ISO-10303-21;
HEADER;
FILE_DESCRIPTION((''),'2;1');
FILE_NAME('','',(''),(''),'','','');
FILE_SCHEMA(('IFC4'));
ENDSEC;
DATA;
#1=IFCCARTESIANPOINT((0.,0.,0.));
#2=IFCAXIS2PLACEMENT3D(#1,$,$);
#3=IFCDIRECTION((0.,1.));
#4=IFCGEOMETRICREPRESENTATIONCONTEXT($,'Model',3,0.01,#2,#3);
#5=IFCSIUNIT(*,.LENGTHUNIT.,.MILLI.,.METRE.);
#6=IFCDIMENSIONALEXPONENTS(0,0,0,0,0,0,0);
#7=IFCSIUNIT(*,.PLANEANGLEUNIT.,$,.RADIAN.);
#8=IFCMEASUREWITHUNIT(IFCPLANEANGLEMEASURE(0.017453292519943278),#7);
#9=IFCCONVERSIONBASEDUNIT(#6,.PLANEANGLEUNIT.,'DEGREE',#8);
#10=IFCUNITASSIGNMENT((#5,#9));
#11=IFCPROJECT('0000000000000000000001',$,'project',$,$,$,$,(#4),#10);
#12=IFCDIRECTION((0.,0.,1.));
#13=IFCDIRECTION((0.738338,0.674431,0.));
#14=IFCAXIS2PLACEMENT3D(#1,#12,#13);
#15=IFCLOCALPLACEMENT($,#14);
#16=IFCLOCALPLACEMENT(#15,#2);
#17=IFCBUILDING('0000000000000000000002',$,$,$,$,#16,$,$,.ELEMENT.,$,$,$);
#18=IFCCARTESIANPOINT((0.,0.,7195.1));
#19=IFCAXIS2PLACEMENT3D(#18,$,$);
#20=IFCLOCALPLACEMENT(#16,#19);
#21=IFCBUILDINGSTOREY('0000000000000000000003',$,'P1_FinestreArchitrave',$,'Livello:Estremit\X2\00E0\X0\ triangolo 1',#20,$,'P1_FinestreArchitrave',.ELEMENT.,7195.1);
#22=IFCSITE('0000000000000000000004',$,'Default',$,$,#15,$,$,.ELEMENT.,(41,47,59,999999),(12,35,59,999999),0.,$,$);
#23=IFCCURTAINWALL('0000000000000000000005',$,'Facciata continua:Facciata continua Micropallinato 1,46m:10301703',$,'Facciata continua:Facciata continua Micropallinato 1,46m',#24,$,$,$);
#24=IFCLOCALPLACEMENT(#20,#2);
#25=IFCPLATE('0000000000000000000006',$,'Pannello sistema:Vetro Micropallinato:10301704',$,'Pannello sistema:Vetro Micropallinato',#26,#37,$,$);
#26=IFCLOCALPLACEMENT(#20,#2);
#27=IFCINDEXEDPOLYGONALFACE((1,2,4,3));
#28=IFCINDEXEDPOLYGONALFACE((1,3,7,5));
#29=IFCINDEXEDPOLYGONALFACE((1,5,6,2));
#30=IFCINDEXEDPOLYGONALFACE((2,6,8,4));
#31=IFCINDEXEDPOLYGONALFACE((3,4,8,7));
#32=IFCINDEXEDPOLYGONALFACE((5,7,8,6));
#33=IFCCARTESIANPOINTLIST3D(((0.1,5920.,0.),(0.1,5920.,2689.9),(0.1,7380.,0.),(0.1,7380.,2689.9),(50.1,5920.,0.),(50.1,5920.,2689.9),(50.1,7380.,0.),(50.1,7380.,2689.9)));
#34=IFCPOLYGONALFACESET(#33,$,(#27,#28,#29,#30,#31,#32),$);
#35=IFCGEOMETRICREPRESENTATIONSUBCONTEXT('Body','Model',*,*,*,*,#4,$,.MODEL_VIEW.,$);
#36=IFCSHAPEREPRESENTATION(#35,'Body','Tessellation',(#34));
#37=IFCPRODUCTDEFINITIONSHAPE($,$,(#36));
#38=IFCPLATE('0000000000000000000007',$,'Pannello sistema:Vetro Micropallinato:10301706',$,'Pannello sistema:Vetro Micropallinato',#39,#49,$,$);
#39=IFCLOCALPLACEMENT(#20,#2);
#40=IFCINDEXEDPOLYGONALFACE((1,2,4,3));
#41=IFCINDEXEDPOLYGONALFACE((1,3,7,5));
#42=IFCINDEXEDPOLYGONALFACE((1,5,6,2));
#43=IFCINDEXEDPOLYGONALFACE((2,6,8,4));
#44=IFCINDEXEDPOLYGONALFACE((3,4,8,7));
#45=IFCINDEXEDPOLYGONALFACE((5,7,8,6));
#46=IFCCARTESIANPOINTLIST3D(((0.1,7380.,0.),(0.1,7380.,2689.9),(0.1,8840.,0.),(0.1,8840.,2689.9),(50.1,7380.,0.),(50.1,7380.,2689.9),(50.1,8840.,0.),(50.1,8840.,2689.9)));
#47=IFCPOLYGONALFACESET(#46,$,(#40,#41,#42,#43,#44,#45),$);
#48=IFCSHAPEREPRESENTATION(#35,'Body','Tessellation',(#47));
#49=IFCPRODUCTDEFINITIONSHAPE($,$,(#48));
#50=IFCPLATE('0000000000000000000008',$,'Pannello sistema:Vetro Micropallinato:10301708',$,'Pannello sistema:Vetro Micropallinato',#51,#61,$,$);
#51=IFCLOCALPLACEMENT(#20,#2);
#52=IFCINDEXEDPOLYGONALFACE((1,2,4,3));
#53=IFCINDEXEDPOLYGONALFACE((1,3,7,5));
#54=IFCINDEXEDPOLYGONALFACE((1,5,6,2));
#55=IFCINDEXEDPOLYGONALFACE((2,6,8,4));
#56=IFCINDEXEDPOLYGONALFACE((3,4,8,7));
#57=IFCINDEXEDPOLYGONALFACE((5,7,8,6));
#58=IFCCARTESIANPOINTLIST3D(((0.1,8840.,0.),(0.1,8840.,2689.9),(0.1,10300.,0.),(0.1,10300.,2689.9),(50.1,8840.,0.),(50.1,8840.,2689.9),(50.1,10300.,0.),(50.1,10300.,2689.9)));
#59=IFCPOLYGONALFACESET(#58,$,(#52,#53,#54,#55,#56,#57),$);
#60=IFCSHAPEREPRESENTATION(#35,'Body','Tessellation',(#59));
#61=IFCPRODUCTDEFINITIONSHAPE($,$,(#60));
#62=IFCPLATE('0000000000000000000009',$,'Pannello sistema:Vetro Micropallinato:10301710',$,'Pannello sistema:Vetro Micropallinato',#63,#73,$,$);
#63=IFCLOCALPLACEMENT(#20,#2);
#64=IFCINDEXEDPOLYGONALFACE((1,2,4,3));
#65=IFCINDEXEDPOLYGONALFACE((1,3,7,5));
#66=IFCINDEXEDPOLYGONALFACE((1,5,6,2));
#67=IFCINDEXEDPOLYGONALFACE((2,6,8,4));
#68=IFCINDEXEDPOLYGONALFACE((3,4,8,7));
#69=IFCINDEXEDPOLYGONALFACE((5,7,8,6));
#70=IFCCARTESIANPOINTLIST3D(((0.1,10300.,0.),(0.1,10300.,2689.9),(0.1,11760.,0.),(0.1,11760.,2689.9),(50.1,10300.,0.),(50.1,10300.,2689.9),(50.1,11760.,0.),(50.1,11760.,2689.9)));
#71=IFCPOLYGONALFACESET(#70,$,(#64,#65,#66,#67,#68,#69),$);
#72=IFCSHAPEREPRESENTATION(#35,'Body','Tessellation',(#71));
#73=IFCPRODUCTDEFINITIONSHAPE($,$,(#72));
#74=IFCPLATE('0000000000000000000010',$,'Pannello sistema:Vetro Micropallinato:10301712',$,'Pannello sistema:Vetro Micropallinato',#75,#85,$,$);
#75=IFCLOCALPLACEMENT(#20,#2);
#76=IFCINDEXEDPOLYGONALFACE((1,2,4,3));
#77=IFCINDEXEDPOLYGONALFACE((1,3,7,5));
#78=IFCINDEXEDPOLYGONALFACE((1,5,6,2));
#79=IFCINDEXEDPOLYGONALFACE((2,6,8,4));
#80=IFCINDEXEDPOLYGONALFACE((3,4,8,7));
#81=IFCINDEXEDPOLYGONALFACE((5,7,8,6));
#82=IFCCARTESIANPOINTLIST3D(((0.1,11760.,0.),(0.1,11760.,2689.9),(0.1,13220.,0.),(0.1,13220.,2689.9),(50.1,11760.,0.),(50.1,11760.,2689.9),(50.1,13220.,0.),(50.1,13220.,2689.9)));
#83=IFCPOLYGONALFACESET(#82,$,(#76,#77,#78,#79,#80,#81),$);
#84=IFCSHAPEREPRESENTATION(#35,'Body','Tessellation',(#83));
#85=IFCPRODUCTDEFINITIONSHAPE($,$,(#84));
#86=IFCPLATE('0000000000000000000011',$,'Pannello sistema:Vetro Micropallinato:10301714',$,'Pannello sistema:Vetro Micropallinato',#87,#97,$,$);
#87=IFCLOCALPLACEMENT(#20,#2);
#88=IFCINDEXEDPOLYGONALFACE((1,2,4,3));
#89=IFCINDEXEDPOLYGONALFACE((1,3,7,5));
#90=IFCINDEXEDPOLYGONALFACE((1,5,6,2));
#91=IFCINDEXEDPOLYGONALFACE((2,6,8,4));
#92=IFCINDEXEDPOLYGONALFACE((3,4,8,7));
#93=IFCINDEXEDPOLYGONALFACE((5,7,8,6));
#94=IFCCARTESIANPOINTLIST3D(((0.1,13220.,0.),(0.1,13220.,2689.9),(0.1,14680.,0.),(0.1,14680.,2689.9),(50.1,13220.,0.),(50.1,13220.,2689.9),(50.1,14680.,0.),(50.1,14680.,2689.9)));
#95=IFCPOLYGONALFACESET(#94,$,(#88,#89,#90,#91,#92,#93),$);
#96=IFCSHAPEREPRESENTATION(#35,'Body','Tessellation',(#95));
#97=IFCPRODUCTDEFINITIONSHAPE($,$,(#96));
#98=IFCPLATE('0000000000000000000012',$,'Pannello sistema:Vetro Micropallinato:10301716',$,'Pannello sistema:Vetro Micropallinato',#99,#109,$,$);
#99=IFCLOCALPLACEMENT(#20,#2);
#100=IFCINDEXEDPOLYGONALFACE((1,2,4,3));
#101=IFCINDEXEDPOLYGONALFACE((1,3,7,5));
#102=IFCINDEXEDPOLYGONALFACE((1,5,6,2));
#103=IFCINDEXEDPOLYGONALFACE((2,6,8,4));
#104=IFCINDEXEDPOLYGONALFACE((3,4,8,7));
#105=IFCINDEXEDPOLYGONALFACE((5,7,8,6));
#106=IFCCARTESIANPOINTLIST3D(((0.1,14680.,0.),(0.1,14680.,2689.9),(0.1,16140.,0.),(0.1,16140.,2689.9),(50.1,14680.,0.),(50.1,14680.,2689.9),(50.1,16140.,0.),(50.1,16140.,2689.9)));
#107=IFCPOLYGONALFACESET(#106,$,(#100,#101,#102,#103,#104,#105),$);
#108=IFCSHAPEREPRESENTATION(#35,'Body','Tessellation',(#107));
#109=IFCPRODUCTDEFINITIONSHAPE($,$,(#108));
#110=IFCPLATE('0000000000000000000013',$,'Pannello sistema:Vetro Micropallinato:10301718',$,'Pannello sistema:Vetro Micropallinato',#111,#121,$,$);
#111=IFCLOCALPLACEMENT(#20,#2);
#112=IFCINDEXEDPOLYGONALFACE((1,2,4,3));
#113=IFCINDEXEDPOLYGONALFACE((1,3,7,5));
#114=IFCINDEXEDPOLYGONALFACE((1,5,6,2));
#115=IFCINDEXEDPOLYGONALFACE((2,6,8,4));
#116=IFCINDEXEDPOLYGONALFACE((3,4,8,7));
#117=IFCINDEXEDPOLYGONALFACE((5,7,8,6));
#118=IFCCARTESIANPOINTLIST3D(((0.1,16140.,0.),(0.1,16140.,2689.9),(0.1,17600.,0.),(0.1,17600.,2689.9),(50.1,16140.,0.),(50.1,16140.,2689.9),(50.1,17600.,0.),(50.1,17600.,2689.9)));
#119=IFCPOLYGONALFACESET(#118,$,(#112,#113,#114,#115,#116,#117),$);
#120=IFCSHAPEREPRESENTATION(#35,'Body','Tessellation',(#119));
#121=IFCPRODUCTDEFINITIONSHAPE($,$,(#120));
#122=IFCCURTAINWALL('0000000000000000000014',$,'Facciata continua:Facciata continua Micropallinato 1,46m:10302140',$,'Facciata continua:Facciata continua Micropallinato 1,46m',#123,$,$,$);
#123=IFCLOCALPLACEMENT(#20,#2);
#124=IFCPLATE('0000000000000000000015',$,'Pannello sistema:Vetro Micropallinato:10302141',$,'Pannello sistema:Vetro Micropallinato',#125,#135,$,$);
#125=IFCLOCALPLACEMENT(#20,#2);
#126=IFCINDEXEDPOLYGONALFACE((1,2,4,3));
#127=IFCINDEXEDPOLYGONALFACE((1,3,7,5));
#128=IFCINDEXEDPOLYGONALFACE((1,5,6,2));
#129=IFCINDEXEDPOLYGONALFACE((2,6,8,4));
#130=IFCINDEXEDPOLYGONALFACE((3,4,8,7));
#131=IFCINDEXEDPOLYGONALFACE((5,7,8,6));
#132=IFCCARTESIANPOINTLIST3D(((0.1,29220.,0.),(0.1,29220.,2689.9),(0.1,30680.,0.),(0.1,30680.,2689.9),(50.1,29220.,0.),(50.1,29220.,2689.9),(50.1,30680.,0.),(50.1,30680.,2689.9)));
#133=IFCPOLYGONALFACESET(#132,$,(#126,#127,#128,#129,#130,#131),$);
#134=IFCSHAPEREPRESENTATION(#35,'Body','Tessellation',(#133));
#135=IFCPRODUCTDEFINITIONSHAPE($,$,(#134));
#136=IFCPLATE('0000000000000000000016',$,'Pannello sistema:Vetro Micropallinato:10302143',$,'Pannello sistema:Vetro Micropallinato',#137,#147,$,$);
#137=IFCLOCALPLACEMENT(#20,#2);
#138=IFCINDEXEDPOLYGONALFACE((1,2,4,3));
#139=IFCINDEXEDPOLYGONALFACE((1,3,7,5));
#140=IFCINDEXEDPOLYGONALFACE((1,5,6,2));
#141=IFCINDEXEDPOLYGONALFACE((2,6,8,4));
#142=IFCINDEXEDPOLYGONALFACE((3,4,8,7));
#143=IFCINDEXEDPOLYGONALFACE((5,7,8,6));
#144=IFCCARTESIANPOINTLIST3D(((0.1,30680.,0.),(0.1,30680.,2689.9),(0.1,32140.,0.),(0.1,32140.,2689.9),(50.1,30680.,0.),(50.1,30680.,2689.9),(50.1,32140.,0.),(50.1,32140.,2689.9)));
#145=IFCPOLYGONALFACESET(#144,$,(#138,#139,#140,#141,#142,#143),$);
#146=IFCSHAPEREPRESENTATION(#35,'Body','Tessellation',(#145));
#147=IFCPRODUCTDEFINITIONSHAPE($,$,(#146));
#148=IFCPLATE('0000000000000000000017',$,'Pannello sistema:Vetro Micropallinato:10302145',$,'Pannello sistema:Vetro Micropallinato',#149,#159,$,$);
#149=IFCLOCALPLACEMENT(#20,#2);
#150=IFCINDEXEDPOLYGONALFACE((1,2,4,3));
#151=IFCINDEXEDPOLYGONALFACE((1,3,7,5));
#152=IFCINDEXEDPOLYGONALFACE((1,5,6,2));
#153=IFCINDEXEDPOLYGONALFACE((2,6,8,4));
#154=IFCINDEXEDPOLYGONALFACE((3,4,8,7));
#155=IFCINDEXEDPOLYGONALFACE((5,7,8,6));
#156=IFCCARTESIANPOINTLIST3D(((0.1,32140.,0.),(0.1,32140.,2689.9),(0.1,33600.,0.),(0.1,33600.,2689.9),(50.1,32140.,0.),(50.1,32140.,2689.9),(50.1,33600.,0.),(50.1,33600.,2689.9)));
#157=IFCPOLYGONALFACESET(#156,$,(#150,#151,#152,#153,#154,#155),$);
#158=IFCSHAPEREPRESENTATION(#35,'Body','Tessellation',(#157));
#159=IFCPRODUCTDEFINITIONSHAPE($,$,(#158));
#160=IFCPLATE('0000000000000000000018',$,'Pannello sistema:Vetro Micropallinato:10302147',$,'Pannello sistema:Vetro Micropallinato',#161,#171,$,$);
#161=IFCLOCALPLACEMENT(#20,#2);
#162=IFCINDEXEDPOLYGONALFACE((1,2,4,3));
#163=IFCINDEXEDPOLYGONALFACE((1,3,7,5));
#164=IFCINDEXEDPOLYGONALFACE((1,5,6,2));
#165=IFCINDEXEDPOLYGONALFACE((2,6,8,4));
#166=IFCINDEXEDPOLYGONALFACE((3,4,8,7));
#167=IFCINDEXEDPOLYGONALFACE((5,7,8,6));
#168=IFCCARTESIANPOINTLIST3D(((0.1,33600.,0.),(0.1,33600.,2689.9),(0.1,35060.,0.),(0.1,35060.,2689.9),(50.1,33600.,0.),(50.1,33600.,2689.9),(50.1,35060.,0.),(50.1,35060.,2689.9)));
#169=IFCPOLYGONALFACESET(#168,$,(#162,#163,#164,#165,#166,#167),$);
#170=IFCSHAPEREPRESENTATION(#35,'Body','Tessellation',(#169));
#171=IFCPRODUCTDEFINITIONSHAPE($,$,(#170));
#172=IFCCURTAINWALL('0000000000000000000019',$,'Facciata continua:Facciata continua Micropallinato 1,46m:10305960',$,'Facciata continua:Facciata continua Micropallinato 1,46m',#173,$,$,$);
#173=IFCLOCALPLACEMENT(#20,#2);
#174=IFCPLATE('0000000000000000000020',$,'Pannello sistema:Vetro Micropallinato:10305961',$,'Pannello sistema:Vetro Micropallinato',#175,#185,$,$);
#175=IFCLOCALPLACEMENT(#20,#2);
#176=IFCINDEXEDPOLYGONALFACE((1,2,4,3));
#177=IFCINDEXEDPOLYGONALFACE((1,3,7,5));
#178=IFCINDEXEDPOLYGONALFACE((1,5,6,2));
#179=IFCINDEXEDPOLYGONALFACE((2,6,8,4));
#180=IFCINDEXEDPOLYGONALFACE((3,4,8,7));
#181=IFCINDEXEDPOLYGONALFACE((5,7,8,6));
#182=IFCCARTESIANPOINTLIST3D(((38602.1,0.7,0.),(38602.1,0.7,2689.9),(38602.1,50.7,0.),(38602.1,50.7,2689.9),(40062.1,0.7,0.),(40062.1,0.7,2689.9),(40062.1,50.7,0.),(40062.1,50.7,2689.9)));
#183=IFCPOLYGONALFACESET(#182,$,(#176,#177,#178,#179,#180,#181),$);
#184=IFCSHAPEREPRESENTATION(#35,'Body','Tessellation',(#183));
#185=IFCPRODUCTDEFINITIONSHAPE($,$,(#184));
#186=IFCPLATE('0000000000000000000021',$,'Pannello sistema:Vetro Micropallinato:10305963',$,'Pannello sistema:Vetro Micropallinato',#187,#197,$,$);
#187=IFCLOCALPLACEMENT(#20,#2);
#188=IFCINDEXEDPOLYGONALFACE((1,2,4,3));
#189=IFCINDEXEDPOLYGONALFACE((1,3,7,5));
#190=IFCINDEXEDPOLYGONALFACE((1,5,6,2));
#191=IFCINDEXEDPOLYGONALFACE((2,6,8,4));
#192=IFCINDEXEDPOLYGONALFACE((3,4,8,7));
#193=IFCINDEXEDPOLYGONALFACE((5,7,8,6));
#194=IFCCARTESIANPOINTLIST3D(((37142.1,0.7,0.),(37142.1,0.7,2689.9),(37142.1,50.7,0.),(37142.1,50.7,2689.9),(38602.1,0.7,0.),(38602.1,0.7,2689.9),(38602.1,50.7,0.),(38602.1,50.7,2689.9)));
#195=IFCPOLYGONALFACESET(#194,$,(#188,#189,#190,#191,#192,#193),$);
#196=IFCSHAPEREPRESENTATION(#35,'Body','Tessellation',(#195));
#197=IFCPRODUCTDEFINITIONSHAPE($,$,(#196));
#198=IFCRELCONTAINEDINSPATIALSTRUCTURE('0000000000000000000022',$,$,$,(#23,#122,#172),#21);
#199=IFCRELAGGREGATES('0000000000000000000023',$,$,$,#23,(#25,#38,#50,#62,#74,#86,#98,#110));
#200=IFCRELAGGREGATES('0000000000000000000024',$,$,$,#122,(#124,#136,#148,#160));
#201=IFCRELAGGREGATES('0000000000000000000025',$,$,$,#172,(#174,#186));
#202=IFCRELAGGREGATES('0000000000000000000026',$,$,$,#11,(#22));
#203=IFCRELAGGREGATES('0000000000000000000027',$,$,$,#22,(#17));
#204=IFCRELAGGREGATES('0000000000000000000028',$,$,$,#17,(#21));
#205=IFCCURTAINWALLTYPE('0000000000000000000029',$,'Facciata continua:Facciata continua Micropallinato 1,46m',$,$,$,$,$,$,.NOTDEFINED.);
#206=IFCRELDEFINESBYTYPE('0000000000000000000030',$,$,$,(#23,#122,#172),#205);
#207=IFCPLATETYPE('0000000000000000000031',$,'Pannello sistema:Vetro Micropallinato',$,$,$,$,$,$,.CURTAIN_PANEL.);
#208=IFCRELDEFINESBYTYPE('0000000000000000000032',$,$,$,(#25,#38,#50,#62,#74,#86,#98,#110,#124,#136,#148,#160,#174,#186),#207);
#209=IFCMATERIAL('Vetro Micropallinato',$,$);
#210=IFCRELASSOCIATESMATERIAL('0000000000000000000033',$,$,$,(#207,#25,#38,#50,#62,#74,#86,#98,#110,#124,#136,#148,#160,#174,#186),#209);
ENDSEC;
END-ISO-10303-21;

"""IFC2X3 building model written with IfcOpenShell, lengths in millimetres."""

from ifc_helpers import new_model, entity, si_unit, converted_unit, direction, frame, origin, origin_2d_with_axis, place, context, subcontext, project, spatial, rectangle, extrude, source, transform, mapped, material, type_object, type_shapes, element, aggregate, save


model = new_model("IFC2X3")

# Units and contexts
model_context = context("Model", 3, precision=0.01, world=origin(), true_north=direction((0.0, 1.0)))
body_context = subcontext(model_context, "Body", "Model", "MODEL_VIEW")
ifc_project = project(units=[si_unit("LENGTHUNIT", "METRE", prefix="MILLI"), converted_unit("PLANEANGLEUNIT", "DEGREE", entity("IfcPlaneAngleMeasure", 0.017453292519943278), si_unit("PLANEANGLEUNIT", "RADIAN"), dimensions=[0, 0, 0, 0, 0, 0, 0])], contexts=[model_context])

# Site, building, storey
site_placement = place(None, frame((0.0, 0.0, 0.0), z_axis=(0.0, 0.0, 1.0), x_axis=(0.738338, 0.674431, 0.0)))
site = spatial("IfcSite", under=ifc_project, at=site_placement, Name="Default", CompositionType="ELEMENT", RefLatitude=(41, 47, 59, 999999), RefLongitude=(12, 35, 59, 999999), RefElevation=0.0)
building_placement = place(site_placement, origin())
building = spatial("IfcBuilding", under=site, at=building_placement, CompositionType="ELEMENT")
storey_placement = place(building_placement, frame((0.0, 0.0, 7195.1)))
storey = spatial("IfcBuildingStorey", under=building, at=storey_placement, Name="P1_FinestreArchitrave", ObjectType="Livello:Estremità triangolo 1", LongName="P1_FinestreArchitrave", CompositionType="ELEMENT", Elevation=7195.1)

# Curtain walls, plates
curtain_wall_type = type_object("IfcCurtainWallType", Name="Facciata continua:Facciata continua Micropallinato 1,46m", PredefinedType="NOTDEFINED")
curtain_wall_1_placement = place(storey_placement, frame((0.0, 0.0, -7195.1)))
curtain_wall_1 = element("IfcCurtainWall", 1, at=curtain_wall_1_placement, inside=storey, type_object=curtain_wall_type, Name="Facciata continua:Facciata continua Micropallinato 1,46m:10301703", ObjectType="Facciata continua:Facciata continua Micropallinato 1,46m")
ifc_material = material(Name="Vetro Micropallinato")
plate_type_1 = type_object("IfcPlateType", Name="Pannello sistema:Vetro Micropallinato", PredefinedType="CURTAIN_PANEL", material=ifc_material)
shared_shape_1 = source(origin(), body_context, "Body", "SweptSolid", [
    extrude(rectangle(XDim=50.0, YDim=1460.0, at=origin_2d_with_axis()), frame((0.0, -25.0, 0.0), z_axis=(0.0, 0.0, 1.0), x_axis=(0.0, 1.0, 0.0)), (0.0, 0.0, 1.0), 2689.9),
])
type_shapes(plate_type_1, [shared_shape_1])
plate_1_placement = place(curtain_wall_1_placement, frame((0.1, 6650.0, 7195.1), z_axis=(0.0, 0.0, 1.0), x_axis=(0.0, 1.0, 0.0)))
plate_1 = element("IfcPlate", 2, at=plate_1_placement, type_object=plate_type_1, material=ifc_material, Name="Pannello sistema:Vetro Micropallinato:10301704", ObjectType="Pannello sistema:Vetro Micropallinato", context=body_context, shape_type="MappedRepresentation", body=[
    mapped(shared_shape_1, transform((0.0, 0.0, 0.0), scale=1.0)),
])
plate_2_placement = place(curtain_wall_1_placement, frame((0.1, 8110.0, 7195.1), z_axis=(0.0, 0.0, 1.0), x_axis=(0.0, 1.0, 0.0)))
plate_2 = element("IfcPlate", 3, at=plate_2_placement, type_object=plate_type_1, material=ifc_material, Name="Pannello sistema:Vetro Micropallinato:10301706", ObjectType="Pannello sistema:Vetro Micropallinato", context=body_context, shape_type="MappedRepresentation", body=[
    mapped(shared_shape_1, transform((0.0, 0.0, 0.0), scale=1.0)),
])
plate_3_placement = place(curtain_wall_1_placement, frame((0.1, 9570.0, 7195.1), z_axis=(0.0, 0.0, 1.0), x_axis=(0.0, 1.0, 0.0)))
plate_3 = element("IfcPlate", 4, at=plate_3_placement, type_object=plate_type_1, material=ifc_material, Name="Pannello sistema:Vetro Micropallinato:10301708", ObjectType="Pannello sistema:Vetro Micropallinato", context=body_context, shape_type="MappedRepresentation", body=[
    mapped(shared_shape_1, transform((0.0, 0.0, 0.0), scale=1.0)),
])
plate_4_placement = place(curtain_wall_1_placement, frame((0.1, 11030.0, 7195.1), z_axis=(0.0, 0.0, 1.0), x_axis=(0.0, 1.0, 0.0)))
plate_4 = element("IfcPlate", 5, at=plate_4_placement, type_object=plate_type_1, material=ifc_material, Name="Pannello sistema:Vetro Micropallinato:10301710", ObjectType="Pannello sistema:Vetro Micropallinato", context=body_context, shape_type="MappedRepresentation", body=[
    mapped(shared_shape_1, transform((0.0, 0.0, 0.0), scale=1.0)),
])
plate_5_placement = place(curtain_wall_1_placement, frame((0.1, 12490.0, 7195.1), z_axis=(0.0, 0.0, 1.0), x_axis=(0.0, 1.0, 0.0)))
plate_5 = element("IfcPlate", 6, at=plate_5_placement, type_object=plate_type_1, material=ifc_material, Name="Pannello sistema:Vetro Micropallinato:10301712", ObjectType="Pannello sistema:Vetro Micropallinato", context=body_context, shape_type="MappedRepresentation", body=[
    mapped(shared_shape_1, transform((0.0, 0.0, 0.0), scale=1.0)),
])
plate_6_placement = place(curtain_wall_1_placement, frame((0.1, 13950.0, 7195.1), z_axis=(0.0, 0.0, 1.0), x_axis=(0.0, 1.0, 0.0)))
plate_6 = element("IfcPlate", 7, at=plate_6_placement, type_object=plate_type_1, material=ifc_material, Name="Pannello sistema:Vetro Micropallinato:10301714", ObjectType="Pannello sistema:Vetro Micropallinato", context=body_context, shape_type="MappedRepresentation", body=[
    mapped(shared_shape_1, transform((0.0, 0.0, 0.0), scale=1.0)),
])
plate_7_placement = place(curtain_wall_1_placement, frame((0.1, 15410.0, 7195.1), z_axis=(0.0, 0.0, 1.0), x_axis=(0.0, 1.0, 0.0)))
plate_7 = element("IfcPlate", 8, at=plate_7_placement, type_object=plate_type_1, material=ifc_material, Name="Pannello sistema:Vetro Micropallinato:10301716", ObjectType="Pannello sistema:Vetro Micropallinato", context=body_context, shape_type="MappedRepresentation", body=[
    mapped(shared_shape_1, transform((0.0, 0.0, 0.0), scale=1.0)),
])
plate_8_placement = place(curtain_wall_1_placement, frame((0.1, 16870.0, 7195.1), z_axis=(0.0, 0.0, 1.0), x_axis=(0.0, 1.0, 0.0)))
plate_8 = element("IfcPlate", 9, at=plate_8_placement, type_object=plate_type_1, material=ifc_material, Name="Pannello sistema:Vetro Micropallinato:10301718", ObjectType="Pannello sistema:Vetro Micropallinato", context=body_context, shape_type="MappedRepresentation", body=[
    mapped(shared_shape_1, transform((0.0, 0.0, 0.0), scale=1.0)),
])
curtain_wall_2_placement = place(storey_placement, frame((0.0, 0.0, -7195.1)))
curtain_wall_2 = element("IfcCurtainWall", 10, at=curtain_wall_2_placement, inside=storey, type_object=curtain_wall_type, Name="Facciata continua:Facciata continua Micropallinato 1,46m:10302140", ObjectType="Facciata continua:Facciata continua Micropallinato 1,46m")
plate_9_placement = place(curtain_wall_2_placement, frame((0.1, 29950.0, 7195.1), z_axis=(0.0, 0.0, 1.0), x_axis=(0.0, 1.0, 0.0)))
plate_9 = element("IfcPlate", 11, at=plate_9_placement, type_object=plate_type_1, material=ifc_material, Name="Pannello sistema:Vetro Micropallinato:10302141", ObjectType="Pannello sistema:Vetro Micropallinato", context=body_context, shape_type="MappedRepresentation", body=[
    mapped(shared_shape_1, transform((0.0, 0.0, 0.0), scale=1.0)),
])
plate_10_placement = place(curtain_wall_2_placement, frame((0.1, 31410.0, 7195.1), z_axis=(0.0, 0.0, 1.0), x_axis=(0.0, 1.0, 0.0)))
plate_10 = element("IfcPlate", 12, at=plate_10_placement, type_object=plate_type_1, material=ifc_material, Name="Pannello sistema:Vetro Micropallinato:10302143", ObjectType="Pannello sistema:Vetro Micropallinato", context=body_context, shape_type="MappedRepresentation", body=[
    mapped(shared_shape_1, transform((0.0, 0.0, 0.0), scale=1.0)),
])
plate_11_placement = place(curtain_wall_2_placement, frame((0.1, 32870.0, 7195.1), z_axis=(0.0, 0.0, 1.0), x_axis=(0.0, 1.0, 0.0)))
plate_11 = element("IfcPlate", 13, at=plate_11_placement, type_object=plate_type_1, material=ifc_material, Name="Pannello sistema:Vetro Micropallinato:10302145", ObjectType="Pannello sistema:Vetro Micropallinato", context=body_context, shape_type="MappedRepresentation", body=[
    mapped(shared_shape_1, transform((0.0, 0.0, 0.0), scale=1.0)),
])
plate_12_placement = place(curtain_wall_2_placement, frame((0.1, 34330.0, 7195.1), z_axis=(0.0, 0.0, 1.0), x_axis=(0.0, 1.0, 0.0)))
plate_12 = element("IfcPlate", 14, at=plate_12_placement, type_object=plate_type_1, material=ifc_material, Name="Pannello sistema:Vetro Micropallinato:10302147", ObjectType="Pannello sistema:Vetro Micropallinato", context=body_context, shape_type="MappedRepresentation", body=[
    mapped(shared_shape_1, transform((0.0, 0.0, 0.0), scale=1.0)),
])
curtain_wall_3_placement = place(storey_placement, frame((0.0, 0.0, -7195.1)))
curtain_wall_3 = element("IfcCurtainWall", 15, at=curtain_wall_3_placement, inside=storey, type_object=curtain_wall_type, Name="Facciata continua:Facciata continua Micropallinato 1,46m:10305960", ObjectType="Facciata continua:Facciata continua Micropallinato 1,46m")
plate_13_placement = place(curtain_wall_3_placement, frame((39332.1, 0.7, 7195.1), z_axis=(0.0, 0.0, 1.0), x_axis=(-1.0, 0.0, 0.0)))
plate_13 = element("IfcPlate", 16, at=plate_13_placement, type_object=plate_type_1, material=ifc_material, Name="Pannello sistema:Vetro Micropallinato:10305961", ObjectType="Pannello sistema:Vetro Micropallinato", context=body_context, shape_type="MappedRepresentation", body=[
    mapped(shared_shape_1, transform((0.0, 0.0, 0.0), scale=1.0)),
])
plate_14_placement = place(curtain_wall_3_placement, frame((37872.1, 0.7, 7195.1), z_axis=(0.0, 0.0, 1.0), x_axis=(-1.0, 0.0, 0.0)))
plate_14 = element("IfcPlate", 17, at=plate_14_placement, type_object=plate_type_1, material=ifc_material, Name="Pannello sistema:Vetro Micropallinato:10305963", ObjectType="Pannello sistema:Vetro Micropallinato", context=body_context, shape_type="MappedRepresentation", body=[
    mapped(shared_shape_1, transform((0.0, 0.0, 0.0), scale=1.0)),
])

aggregate(curtain_wall_1, [plate_1, plate_2, plate_3, plate_4, plate_5, plate_6, plate_7, plate_8])
aggregate(curtain_wall_2, [plate_9, plate_10, plate_11, plate_12])
aggregate(curtain_wall_3, [plate_13, plate_14])

save(model, "model.ifc")
